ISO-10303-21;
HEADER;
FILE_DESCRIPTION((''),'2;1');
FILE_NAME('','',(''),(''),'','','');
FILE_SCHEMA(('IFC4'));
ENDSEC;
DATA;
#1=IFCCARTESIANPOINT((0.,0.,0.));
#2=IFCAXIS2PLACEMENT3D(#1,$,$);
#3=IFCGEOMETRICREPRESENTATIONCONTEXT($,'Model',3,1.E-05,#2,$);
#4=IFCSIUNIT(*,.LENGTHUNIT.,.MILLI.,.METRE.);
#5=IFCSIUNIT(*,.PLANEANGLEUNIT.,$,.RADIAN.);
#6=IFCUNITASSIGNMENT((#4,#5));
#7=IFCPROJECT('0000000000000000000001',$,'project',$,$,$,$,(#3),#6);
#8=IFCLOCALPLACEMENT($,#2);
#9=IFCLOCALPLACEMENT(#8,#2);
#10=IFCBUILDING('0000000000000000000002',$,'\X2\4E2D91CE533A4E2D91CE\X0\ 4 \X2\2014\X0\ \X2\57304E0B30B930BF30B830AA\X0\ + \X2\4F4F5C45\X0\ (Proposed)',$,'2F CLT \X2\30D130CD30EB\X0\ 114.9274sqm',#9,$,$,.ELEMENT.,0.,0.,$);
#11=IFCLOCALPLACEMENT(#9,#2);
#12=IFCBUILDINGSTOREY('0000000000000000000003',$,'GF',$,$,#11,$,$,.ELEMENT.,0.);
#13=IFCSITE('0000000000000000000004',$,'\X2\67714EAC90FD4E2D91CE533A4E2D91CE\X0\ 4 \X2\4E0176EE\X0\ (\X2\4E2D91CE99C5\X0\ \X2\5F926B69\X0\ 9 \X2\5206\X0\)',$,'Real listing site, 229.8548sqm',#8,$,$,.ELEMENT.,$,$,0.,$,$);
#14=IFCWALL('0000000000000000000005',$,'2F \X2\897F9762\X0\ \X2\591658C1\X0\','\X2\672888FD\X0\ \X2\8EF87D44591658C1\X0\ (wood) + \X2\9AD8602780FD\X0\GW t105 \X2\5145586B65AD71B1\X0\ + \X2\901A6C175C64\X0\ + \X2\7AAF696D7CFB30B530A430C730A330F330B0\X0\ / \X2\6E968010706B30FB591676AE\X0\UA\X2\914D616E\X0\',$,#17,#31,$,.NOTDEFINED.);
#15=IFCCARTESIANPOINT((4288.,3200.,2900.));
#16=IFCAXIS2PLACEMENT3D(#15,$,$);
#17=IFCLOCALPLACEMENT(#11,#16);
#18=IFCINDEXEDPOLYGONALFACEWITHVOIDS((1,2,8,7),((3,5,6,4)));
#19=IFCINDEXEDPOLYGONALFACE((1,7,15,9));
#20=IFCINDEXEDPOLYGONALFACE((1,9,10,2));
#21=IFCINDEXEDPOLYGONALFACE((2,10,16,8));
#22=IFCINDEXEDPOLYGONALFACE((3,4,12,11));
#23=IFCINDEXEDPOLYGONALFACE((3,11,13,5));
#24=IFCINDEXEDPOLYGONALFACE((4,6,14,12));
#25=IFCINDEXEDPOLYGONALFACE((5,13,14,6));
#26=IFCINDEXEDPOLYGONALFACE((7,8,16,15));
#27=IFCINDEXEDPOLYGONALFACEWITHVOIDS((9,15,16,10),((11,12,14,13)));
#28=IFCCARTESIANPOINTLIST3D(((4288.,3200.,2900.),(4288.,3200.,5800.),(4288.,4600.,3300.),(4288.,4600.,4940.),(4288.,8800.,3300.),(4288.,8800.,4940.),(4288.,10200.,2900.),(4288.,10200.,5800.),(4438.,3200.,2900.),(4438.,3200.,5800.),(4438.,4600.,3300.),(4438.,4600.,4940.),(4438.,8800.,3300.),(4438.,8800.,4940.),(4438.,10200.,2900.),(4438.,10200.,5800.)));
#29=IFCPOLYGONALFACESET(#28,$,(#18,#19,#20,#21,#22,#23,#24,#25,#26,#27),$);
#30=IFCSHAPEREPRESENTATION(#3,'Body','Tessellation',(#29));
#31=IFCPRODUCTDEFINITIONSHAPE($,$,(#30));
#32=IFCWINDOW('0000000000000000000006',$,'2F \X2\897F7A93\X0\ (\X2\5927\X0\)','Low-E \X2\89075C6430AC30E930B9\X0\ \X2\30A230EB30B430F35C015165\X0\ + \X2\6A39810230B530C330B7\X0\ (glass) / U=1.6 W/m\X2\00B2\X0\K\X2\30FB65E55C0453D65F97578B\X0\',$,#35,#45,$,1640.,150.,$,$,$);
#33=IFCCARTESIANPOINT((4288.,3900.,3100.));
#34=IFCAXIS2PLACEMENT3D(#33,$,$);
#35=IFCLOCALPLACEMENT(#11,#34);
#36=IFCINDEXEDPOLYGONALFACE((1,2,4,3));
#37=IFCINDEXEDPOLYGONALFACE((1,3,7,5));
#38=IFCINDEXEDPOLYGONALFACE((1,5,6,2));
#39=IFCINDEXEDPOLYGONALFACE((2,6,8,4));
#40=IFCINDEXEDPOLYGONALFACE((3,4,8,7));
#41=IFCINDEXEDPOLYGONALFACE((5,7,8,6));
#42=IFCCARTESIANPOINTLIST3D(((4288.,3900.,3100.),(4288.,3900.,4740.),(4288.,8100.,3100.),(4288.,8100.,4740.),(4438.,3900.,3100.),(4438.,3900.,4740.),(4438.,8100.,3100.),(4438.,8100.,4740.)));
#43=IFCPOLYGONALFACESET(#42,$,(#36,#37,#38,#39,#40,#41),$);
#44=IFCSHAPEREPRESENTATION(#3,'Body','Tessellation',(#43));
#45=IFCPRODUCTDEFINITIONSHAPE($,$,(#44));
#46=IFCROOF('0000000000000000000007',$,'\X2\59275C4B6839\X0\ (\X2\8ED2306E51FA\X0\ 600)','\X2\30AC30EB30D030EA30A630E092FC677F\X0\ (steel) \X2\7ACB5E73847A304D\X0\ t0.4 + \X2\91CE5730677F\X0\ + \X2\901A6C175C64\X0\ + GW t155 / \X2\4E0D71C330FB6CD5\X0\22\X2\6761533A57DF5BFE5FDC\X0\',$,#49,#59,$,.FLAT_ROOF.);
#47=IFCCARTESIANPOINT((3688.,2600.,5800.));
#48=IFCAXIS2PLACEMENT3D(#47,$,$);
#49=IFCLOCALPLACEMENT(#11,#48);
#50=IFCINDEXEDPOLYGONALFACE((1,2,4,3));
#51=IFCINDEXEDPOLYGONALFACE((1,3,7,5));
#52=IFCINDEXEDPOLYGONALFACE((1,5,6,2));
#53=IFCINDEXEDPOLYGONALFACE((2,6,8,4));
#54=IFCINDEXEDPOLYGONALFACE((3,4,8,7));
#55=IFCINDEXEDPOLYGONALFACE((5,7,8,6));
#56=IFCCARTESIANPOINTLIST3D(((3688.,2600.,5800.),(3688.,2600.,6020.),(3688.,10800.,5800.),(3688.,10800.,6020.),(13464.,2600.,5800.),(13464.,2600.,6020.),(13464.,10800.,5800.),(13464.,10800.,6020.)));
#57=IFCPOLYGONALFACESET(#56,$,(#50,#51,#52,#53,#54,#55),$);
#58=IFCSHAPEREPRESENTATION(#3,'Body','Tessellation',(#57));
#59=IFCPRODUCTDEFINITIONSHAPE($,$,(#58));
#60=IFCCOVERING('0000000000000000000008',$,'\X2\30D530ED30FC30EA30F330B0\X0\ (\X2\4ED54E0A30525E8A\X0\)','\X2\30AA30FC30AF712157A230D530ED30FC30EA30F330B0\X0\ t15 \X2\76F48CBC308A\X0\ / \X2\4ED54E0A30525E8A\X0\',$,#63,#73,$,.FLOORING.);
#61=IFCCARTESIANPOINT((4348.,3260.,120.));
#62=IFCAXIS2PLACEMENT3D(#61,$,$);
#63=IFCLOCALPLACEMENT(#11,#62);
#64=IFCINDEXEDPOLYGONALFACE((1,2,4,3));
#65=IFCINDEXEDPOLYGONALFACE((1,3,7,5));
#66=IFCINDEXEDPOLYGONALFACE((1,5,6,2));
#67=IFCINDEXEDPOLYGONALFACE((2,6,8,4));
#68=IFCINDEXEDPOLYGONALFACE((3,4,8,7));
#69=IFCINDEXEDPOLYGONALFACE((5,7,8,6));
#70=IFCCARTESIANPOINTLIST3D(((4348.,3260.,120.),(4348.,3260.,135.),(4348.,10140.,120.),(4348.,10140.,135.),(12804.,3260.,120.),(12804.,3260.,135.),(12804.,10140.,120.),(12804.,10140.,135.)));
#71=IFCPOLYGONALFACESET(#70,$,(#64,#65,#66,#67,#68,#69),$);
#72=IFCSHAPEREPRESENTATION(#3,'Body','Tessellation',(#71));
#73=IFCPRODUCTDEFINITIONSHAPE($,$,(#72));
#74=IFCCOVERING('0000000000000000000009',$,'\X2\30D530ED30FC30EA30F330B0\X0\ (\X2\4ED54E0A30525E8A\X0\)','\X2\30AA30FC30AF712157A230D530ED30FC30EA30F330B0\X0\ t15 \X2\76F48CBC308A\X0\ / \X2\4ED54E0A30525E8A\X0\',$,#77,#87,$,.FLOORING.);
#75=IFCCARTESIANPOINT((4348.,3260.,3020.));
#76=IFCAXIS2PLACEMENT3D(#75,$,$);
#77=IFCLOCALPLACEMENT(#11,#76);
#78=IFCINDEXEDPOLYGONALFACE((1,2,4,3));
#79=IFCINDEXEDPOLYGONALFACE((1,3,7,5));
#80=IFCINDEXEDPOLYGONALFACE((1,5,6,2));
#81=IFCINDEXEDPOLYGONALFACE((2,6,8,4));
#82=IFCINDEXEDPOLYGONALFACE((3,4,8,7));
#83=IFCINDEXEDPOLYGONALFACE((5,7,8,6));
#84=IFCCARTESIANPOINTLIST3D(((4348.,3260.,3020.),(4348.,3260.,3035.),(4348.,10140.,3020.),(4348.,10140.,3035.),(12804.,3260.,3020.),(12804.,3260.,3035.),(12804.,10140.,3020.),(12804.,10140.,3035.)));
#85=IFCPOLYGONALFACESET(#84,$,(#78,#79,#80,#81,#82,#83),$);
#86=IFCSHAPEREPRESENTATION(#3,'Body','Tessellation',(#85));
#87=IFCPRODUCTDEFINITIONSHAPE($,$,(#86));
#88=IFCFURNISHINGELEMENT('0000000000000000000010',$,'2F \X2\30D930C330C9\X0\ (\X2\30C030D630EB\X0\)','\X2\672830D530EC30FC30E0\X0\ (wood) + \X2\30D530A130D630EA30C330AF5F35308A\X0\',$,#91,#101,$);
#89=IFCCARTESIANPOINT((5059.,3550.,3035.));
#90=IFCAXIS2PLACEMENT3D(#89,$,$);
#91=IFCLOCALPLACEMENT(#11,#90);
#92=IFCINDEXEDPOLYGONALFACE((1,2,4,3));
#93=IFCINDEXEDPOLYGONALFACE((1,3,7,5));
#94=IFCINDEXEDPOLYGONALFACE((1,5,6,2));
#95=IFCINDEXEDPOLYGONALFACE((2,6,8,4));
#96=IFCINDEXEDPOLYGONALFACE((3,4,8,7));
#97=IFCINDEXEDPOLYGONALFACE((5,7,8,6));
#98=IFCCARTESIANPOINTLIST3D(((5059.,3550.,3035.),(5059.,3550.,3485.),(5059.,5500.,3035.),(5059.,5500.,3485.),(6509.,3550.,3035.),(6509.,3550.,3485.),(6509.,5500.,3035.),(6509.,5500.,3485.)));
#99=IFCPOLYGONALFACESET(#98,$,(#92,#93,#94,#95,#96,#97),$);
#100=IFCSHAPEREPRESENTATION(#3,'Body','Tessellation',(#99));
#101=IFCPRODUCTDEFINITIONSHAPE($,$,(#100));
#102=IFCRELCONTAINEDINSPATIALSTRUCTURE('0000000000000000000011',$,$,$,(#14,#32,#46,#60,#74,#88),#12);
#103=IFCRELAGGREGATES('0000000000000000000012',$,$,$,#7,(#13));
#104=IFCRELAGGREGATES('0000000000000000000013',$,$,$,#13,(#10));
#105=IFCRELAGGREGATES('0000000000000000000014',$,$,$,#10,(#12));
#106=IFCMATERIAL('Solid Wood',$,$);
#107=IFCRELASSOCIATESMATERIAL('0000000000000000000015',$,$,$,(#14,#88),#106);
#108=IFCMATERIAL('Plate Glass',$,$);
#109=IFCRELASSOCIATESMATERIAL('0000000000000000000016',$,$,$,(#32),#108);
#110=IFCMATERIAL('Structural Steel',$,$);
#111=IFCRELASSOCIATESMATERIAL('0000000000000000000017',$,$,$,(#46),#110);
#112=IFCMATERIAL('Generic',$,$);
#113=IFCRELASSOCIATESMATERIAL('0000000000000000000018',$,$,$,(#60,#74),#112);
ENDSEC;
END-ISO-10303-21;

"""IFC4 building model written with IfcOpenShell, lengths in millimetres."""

from ifc_helpers import new_model, si_unit, frame, frame_2d, origin, place, context, project, spatial, rectangle, extrude, material, element, fill, save


model = new_model("IFC4")

# Units and contexts
model_context = context("Model", 3, precision=1e-05, world=origin())
ifc_project = project(units=[si_unit("LENGTHUNIT", "METRE", prefix="MILLI"), si_unit("PLANEANGLEUNIT", "RADIAN")], contexts=[model_context])

# Site, building, storey
site_placement = place(None, origin())
site = spatial("IfcSite", under=ifc_project, at=site_placement, Name="東京都中野区中野 4 丁目 (中野駅 徒歩 9 分)", ObjectType="Real listing site, 229.8548sqm", CompositionType="ELEMENT", RefElevation=0.0)
building_placement = place(site_placement, origin())
building = spatial("IfcBuilding", under=site, at=building_placement, Name="中野区中野 4 — 地下スタジオ + 住居 (Proposed)", ObjectType="2F CLT パネル 114.9274sqm", CompositionType="ELEMENT", ElevationOfRefHeight=0.0, ElevationOfTerrain=0.0)
storey_placement = place(building_placement, origin())
storey = spatial("IfcBuildingStorey", under=building, at=storey_placement, Name="GF", CompositionType="ELEMENT", Elevation=0.0)

# Shared definitions
ifc_material_1 = material(Name="Solid Wood")

# Shared definitions
ifc_material_2 = material(Name="Plate Glass")

# Wall, opening, window
wall_1_placement = place(storey_placement, frame((4288.0, 3200.0, 2900.0)))
wall_1 = element("IfcWall", 1, at=wall_1_placement, inside=storey, material=ifc_material_1, Name="2F 西面 外壁", Description="木製 軸組外壁 (wood) + 高性能GW t105 充填断熱 + 通気層 + 窯業系サイディング / 準耐火・外皮UA配慮", PredefinedType="NOTDEFINED", context=model_context, shape_type="SweptSolid", body=[
    extrude(rectangle(XDim=150.0, YDim=7000.0, at=frame_2d((75.0, 3500.0))), frame((4288.0, 3200.0, 2900.0)), (0.0, 0.0, 1.0), 2900.0),
])
opening_1_placement = place(storey_placement, frame((4288.0, 3900.0, 3100.0)))
opening_1 = element("IfcOpeningElement", 2, at=opening_1_placement, cuts=wall_1, PredefinedType="NOTDEFINED", context=model_context, shape_type="SweptSolid", body=[
    extrude(rectangle(XDim=150.0, YDim=4200.0, at=frame_2d((75.0, 2100.0))), frame((4288.0, 3900.0, 3100.0)), (0.0, 0.0, 1.0), 1640.0),
])
window_1_placement = place(storey_placement, frame((4288.0, 3900.0, 3100.0)))
window_1 = element("IfcWindow", 3, at=window_1_placement, inside=storey, material=ifc_material_2, Name="2F 西窓 (大)", Description="Low-E 複層ガラス アルゴン封入 + 樹脂サッシ (glass) / U=1.6 W/m²K・日射取得型", OverallHeight=1640.0, OverallWidth=150.0, context=model_context, shape_type="SweptSolid", body=[
    extrude(rectangle(XDim=150.0, YDim=4200.0, at=frame_2d((75.0, 2100.0))), frame((4288.0, 3900.0, 3100.0)), (0.0, 0.0, 1.0), 1640.0),
])
fill(opening_1, window_1)

# Roof
ifc_material_3 = material(Name="Structural Steel")
roof_placement = place(storey_placement, frame((3688.0, 2600.0, 5800.0)))
element("IfcRoof", 4, at=roof_placement, inside=storey, material=ifc_material_3, Name="大屋根 (軒の出 600)", Description="ガルバリウム鋼板 (steel) 立平葺き t0.4 + 野地板 + 通気層 + GW t155 / 不燃・法22条区域対応", PredefinedType="FLAT_ROOF", context=model_context, shape_type="SweptSolid", body=[
    extrude(rectangle(XDim=9776.0, YDim=8200.0, at=frame_2d((4888.0, 4100.0))), frame((3688.0, 2600.0, 5800.0)), (0.0, 0.0, 1.0), 220.0),
])

# Coverings
ifc_material_4 = material(Name="Generic")
covering_1_placement = place(storey_placement, frame((4348.0, 3260.0, 120.0)))
element("IfcCovering", 5, at=covering_1_placement, inside=storey, material=ifc_material_4, Name="フローリング (仕上げ床)", Description="オーク無垢フローリング t15 直貼り / 仕上げ床", PredefinedType="FLOORING", context=model_context, shape_type="SweptSolid", body=[
    extrude(rectangle(XDim=8456.0, YDim=6880.0, at=frame_2d((4228.0, 3440.0))), frame((4348.0, 3260.0, 120.0)), (0.0, 0.0, 1.0), 15.0),
])
covering_2_placement = place(storey_placement, frame((4348.0, 3260.0, 3020.0)))
element("IfcCovering", 6, at=covering_2_placement, inside=storey, material=ifc_material_4, Name="フローリング (仕上げ床)", Description="オーク無垢フローリング t15 直貼り / 仕上げ床", PredefinedType="FLOORING", context=model_context, shape_type="SweptSolid", body=[
    extrude(rectangle(XDim=8456.0, YDim=6880.0, at=frame_2d((4228.0, 3440.0))), frame((4348.0, 3260.0, 3020.0)), (0.0, 0.0, 1.0), 15.0),
])

# Furnishing element
furnishing_placement = place(storey_placement, frame((5059.0, 3550.0, 3035.0)))
element("IfcFurnishingElement", 7, at=furnishing_placement, inside=storey, material=ifc_material_1, Name="2F ベッド (ダブル)", Description="木フレーム (wood) + ファブリック張り", context=model_context, shape_type="SweptSolid", body=[
    extrude(rectangle(XDim=1450.0, YDim=1950.0, at=frame_2d((725.0, 975.0))), frame((5059.0, 3550.0, 3035.0)), (0.0, 0.0, 1.0), 450.0),
])

save(model, "model.ifc")
